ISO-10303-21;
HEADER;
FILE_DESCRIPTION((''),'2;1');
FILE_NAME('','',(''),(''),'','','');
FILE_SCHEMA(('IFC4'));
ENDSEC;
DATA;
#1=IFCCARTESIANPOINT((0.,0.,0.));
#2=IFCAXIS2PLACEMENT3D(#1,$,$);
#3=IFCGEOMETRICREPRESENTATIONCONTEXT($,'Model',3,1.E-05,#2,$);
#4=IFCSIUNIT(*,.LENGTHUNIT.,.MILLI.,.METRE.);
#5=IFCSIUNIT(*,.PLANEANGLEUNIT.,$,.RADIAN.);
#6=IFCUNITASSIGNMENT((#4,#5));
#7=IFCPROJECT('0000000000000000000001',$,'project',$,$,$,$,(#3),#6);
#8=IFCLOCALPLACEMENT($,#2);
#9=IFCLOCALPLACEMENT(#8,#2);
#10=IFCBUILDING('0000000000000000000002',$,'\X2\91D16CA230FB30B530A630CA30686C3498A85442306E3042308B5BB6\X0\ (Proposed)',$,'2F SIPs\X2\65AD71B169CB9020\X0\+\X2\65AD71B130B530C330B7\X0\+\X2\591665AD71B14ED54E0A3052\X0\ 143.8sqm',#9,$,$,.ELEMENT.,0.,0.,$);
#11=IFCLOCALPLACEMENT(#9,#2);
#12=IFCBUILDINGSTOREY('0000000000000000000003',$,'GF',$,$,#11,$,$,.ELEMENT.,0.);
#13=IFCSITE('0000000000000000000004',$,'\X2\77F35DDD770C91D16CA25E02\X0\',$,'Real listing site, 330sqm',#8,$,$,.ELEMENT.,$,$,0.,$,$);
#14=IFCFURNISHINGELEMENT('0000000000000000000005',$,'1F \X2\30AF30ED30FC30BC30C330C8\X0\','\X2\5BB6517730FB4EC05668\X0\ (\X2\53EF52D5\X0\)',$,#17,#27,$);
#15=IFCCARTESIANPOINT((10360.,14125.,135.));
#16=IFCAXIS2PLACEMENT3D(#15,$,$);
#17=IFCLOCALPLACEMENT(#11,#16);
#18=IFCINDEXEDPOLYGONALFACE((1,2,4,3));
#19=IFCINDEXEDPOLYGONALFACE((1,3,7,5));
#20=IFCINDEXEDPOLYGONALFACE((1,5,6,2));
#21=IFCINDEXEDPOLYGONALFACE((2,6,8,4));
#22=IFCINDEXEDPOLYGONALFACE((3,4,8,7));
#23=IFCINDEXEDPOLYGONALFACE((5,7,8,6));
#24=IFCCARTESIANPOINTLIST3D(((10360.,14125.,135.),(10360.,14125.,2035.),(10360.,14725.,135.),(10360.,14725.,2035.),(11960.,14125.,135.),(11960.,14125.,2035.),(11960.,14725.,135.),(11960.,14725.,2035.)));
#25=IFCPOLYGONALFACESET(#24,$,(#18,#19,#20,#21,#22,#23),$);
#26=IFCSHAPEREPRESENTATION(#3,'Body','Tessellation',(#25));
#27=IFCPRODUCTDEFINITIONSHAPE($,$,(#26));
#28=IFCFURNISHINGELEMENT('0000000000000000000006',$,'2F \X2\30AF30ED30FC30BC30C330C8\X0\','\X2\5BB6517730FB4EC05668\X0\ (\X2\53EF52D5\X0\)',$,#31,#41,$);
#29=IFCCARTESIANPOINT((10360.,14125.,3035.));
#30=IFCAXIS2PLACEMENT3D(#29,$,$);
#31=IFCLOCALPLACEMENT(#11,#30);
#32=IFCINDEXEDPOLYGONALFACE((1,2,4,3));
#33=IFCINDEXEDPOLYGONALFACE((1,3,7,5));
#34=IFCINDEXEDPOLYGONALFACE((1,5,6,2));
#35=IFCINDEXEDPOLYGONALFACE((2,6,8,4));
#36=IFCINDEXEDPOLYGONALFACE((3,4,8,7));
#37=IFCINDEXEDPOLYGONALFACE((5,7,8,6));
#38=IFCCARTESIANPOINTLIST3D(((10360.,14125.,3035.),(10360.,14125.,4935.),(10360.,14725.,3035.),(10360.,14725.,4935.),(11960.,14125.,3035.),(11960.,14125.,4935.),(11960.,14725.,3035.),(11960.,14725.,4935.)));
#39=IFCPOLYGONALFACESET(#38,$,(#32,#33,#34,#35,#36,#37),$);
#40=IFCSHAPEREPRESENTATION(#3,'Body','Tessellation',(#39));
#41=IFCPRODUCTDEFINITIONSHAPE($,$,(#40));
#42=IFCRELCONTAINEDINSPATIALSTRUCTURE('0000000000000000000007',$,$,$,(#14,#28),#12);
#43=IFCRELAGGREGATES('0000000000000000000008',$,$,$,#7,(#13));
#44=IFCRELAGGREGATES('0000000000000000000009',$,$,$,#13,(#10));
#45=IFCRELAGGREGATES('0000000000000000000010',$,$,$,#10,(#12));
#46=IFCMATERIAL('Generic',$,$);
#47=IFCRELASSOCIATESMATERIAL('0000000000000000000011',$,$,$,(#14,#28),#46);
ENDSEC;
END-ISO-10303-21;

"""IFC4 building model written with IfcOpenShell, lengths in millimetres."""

from ifc_helpers import new_model, si_unit, frame, frame_2d, origin, place, context, project, spatial, rectangle, extrude, material, element, save


model = new_model("IFC4")

# Units and contexts
model_context = context("Model", 3, precision=1e-05, world=origin())
ifc_project = project(units=[si_unit("LENGTHUNIT", "METRE", prefix="MILLI"), si_unit("PLANEANGLEUNIT", "RADIAN")], contexts=[model_context])

# Site, building, storey
site_placement = place(None, origin())
site = spatial("IfcSite", under=ifc_project, at=site_placement, Name="石川県金沢市", ObjectType="Real listing site, 330sqm", CompositionType="ELEMENT", RefElevation=0.0)
building_placement = place(site_placement, origin())
building = spatial("IfcBuilding", under=site, at=building_placement, Name="金沢・サウナと水風呂のある家 (Proposed)", ObjectType="2F SIPs断熱構造+断熱サッシ+外断熱仕上げ 143.8sqm", CompositionType="ELEMENT", ElevationOfRefHeight=0.0, ElevationOfTerrain=0.0)
storey_placement = place(building_placement, origin())
storey = spatial("IfcBuildingStorey", under=building, at=storey_placement, Name="GF", CompositionType="ELEMENT", Elevation=0.0)

# Shared definitions
ifc_material_1 = material(Name="Generic")

# Furnishing elements
furnishing_1_placement = place(storey_placement, frame((10360.0, 14125.0, 135.0)))
element("IfcFurnishingElement", 1, at=furnishing_1_placement, inside=storey, material=ifc_material_1, Name="1F クローゼット", Description="家具・什器 (可動)", context=model_context, shape_type="SweptSolid", body=[
    extrude(rectangle(XDim=1600.0, YDim=600.0, at=frame_2d((800.0, 300.0))), frame((10360.0, 14125.0, 135.0)), (0.0, 0.0, 1.0), 1900.0),
])
furnishing_2_placement = place(storey_placement, frame((10360.0, 14125.0, 3035.0)))
element("IfcFurnishingElement", 2, at=furnishing_2_placement, inside=storey, material=ifc_material_1, Name="2F クローゼット", Description="家具・什器 (可動)", context=model_context, shape_type="SweptSolid", body=[
    extrude(rectangle(XDim=1600.0, YDim=600.0, at=frame_2d((800.0, 300.0))), frame((10360.0, 14125.0, 3035.0)), (0.0, 0.0, 1.0), 1900.0),
])

save(model, "model.ifc")
